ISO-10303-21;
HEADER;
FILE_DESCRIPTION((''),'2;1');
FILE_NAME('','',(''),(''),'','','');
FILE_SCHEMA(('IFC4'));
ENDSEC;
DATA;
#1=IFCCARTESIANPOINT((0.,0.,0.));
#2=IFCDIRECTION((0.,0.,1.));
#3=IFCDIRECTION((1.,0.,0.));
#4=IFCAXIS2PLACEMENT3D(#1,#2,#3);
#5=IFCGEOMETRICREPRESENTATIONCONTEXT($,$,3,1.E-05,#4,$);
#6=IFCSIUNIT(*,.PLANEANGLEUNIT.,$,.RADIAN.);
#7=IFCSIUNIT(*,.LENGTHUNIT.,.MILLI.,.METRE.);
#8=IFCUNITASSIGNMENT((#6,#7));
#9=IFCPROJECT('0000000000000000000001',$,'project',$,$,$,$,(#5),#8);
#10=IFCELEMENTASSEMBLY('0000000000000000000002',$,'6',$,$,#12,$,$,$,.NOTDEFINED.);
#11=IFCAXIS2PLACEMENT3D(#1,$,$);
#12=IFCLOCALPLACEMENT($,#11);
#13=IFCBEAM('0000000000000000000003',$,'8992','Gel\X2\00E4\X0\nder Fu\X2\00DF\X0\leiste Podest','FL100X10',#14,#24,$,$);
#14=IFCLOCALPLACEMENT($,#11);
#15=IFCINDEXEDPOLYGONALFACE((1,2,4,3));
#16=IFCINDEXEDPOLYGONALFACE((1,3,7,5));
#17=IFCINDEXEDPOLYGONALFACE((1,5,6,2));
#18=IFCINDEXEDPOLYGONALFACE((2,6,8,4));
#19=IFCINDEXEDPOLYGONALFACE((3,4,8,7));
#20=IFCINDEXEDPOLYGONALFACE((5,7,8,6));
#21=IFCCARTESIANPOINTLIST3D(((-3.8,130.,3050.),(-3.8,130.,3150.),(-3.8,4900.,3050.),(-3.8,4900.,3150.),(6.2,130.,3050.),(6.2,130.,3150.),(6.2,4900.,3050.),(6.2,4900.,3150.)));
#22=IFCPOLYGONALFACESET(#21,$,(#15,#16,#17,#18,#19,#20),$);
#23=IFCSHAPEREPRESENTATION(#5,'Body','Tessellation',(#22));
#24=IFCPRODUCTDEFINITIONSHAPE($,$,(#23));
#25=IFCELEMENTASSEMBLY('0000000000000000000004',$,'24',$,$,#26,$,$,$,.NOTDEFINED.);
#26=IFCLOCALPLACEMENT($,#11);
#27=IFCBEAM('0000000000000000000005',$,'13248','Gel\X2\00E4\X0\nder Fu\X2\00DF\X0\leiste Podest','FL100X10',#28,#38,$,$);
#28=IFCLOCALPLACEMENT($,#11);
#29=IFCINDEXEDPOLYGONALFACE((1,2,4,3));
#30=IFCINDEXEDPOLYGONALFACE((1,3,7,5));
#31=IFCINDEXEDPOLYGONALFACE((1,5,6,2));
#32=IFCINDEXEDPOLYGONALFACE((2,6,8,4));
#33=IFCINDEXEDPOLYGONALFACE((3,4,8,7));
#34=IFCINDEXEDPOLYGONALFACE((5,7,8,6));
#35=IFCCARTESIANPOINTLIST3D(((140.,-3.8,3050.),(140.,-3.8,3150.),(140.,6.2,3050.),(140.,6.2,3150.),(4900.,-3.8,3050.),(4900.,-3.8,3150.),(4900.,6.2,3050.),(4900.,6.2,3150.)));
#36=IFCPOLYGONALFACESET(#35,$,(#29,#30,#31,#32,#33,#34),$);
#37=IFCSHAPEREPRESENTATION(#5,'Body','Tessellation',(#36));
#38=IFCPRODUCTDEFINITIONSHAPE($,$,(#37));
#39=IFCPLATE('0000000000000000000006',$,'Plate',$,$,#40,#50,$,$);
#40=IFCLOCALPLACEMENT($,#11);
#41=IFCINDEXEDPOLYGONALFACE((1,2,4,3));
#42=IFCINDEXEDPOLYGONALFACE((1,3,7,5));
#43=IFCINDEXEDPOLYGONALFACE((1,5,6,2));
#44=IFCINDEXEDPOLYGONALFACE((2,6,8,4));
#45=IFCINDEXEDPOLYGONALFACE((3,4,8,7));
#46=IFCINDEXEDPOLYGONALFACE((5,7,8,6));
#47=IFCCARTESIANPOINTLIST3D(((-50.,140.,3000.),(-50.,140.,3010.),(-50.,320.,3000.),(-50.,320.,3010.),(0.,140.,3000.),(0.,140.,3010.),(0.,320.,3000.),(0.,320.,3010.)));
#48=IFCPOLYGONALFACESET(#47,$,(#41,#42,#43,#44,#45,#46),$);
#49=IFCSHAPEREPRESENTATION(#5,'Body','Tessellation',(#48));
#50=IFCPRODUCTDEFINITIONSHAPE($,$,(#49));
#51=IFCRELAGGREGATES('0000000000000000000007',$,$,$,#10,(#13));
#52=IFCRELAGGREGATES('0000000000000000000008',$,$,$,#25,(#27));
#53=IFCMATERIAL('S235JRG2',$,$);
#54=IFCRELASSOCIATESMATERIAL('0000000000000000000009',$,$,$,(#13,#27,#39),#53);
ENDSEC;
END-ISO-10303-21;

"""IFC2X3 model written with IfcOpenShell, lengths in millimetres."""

from ifc_helpers import new_model, si_unit, frame, origin_with_axes, place, context, project, polyline, outline, extrude, material, element, aggregate, save


model = new_model("IFC2X3")

# Units and contexts
context_of_model = context(None, 3, precision=1e-05, world=origin_with_axes())
ifc_project = project(units=[si_unit("PLANEANGLEUNIT", "RADIAN"), si_unit("LENGTHUNIT", "METRE", prefix="MILLI")], contexts=[context_of_model])

# Element assemblies, beams
assembly_1_placement = place(None, frame((1.2, 5130.0, 6100.0), z_axis=(0.0, 0.0, 1.0), x_axis=(0.0, 1.0, 0.0)))
assembly_1 = element("IfcElementAssembly", 1, at=assembly_1_placement, Name="6", PredefinedType="NOTDEFINED")
ifc_material = material(Name="S235JRG2")
placement_1 = place(None, frame((1.2, 130.0, 3100.0), z_axis=(0.0, 0.0, 1.0), x_axis=(0.0, 1.0, 0.0)))
beam_1_placement = place(placement_1, origin_with_axes())
beam_1 = element("IfcBeam", 2, at=beam_1_placement, material=ifc_material, Name="8992", Description="Geländer Fußleiste Podest", ObjectType="FL100X10", context=context_of_model, shape_type="SweptSolid", body=[
    extrude(outline(polyline([(5.0, -50.0), (5.0, 50.0), (-5.0, 50.0), (-5.0, -50.0), (5.0, -50.0), (5.0, -50.0)])), frame((0.0, 0.0, 0.0), z_axis=(1.0, 0.0, 0.0), x_axis=(0.0, 1.0, 0.0)), (0.0, 0.0, 1.0), 4770.0),
])
aggregate(assembly_1, [beam_1])
assembly_2_placement = place(None, frame((140.0, 9998.8, 6100.0), z_axis=(0.0, 0.0, 1.0), x_axis=(1.0, 0.0, 0.0)))
assembly_2 = element("IfcElementAssembly", 3, at=assembly_2_placement, Name="24", PredefinedType="NOTDEFINED")
placement_2 = place(None, frame((140.0, 1.2, 3100.0), z_axis=(0.0, 0.0, 1.0), x_axis=(1.0, 0.0, 0.0)))
beam_2_placement = place(placement_2, origin_with_axes())
beam_2 = element("IfcBeam", 4, at=beam_2_placement, material=ifc_material, Name="13248", Description="Geländer Fußleiste Podest", ObjectType="FL100X10", context=context_of_model, shape_type="SweptSolid", body=[
    extrude(outline(polyline([(5.0, -50.0), (5.0, 50.0), (-5.0, 50.0), (-5.0, -50.0), (5.0, -50.0), (5.0, -50.0)])), frame((0.0, 0.0, 0.0), z_axis=(1.0, 0.0, 0.0), x_axis=(0.0, 1.0, 0.0)), (0.0, 0.0, 1.0), 4760.0),
])
aggregate(assembly_2, [beam_2])

# Plate
placement_3 = place(None, origin_with_axes())
plate_placement = place(placement_3, frame((0.0, 320.0, 3010.0), z_axis=(-1.0, 0.0, 0.0), x_axis=(0.0, 0.0, -1.0)))
element("IfcPlate", 5, at=plate_placement, material=ifc_material, Name="Plate", context=context_of_model, shape_type="SweptSolid", body=[
    extrude(outline(polyline([(0.0, 0.0), (180.0, 0.0), (180.0, 50.0), (0.0, 50.0), (0.0, 0.0)])), frame((0.0, 0.0, 0.0), z_axis=(1.0, 0.0, 0.0), x_axis=(0.0, 1.0, 0.0)), (0.0, 0.0, 1.0), 10.0),
])

save(model, "model.ifc")
